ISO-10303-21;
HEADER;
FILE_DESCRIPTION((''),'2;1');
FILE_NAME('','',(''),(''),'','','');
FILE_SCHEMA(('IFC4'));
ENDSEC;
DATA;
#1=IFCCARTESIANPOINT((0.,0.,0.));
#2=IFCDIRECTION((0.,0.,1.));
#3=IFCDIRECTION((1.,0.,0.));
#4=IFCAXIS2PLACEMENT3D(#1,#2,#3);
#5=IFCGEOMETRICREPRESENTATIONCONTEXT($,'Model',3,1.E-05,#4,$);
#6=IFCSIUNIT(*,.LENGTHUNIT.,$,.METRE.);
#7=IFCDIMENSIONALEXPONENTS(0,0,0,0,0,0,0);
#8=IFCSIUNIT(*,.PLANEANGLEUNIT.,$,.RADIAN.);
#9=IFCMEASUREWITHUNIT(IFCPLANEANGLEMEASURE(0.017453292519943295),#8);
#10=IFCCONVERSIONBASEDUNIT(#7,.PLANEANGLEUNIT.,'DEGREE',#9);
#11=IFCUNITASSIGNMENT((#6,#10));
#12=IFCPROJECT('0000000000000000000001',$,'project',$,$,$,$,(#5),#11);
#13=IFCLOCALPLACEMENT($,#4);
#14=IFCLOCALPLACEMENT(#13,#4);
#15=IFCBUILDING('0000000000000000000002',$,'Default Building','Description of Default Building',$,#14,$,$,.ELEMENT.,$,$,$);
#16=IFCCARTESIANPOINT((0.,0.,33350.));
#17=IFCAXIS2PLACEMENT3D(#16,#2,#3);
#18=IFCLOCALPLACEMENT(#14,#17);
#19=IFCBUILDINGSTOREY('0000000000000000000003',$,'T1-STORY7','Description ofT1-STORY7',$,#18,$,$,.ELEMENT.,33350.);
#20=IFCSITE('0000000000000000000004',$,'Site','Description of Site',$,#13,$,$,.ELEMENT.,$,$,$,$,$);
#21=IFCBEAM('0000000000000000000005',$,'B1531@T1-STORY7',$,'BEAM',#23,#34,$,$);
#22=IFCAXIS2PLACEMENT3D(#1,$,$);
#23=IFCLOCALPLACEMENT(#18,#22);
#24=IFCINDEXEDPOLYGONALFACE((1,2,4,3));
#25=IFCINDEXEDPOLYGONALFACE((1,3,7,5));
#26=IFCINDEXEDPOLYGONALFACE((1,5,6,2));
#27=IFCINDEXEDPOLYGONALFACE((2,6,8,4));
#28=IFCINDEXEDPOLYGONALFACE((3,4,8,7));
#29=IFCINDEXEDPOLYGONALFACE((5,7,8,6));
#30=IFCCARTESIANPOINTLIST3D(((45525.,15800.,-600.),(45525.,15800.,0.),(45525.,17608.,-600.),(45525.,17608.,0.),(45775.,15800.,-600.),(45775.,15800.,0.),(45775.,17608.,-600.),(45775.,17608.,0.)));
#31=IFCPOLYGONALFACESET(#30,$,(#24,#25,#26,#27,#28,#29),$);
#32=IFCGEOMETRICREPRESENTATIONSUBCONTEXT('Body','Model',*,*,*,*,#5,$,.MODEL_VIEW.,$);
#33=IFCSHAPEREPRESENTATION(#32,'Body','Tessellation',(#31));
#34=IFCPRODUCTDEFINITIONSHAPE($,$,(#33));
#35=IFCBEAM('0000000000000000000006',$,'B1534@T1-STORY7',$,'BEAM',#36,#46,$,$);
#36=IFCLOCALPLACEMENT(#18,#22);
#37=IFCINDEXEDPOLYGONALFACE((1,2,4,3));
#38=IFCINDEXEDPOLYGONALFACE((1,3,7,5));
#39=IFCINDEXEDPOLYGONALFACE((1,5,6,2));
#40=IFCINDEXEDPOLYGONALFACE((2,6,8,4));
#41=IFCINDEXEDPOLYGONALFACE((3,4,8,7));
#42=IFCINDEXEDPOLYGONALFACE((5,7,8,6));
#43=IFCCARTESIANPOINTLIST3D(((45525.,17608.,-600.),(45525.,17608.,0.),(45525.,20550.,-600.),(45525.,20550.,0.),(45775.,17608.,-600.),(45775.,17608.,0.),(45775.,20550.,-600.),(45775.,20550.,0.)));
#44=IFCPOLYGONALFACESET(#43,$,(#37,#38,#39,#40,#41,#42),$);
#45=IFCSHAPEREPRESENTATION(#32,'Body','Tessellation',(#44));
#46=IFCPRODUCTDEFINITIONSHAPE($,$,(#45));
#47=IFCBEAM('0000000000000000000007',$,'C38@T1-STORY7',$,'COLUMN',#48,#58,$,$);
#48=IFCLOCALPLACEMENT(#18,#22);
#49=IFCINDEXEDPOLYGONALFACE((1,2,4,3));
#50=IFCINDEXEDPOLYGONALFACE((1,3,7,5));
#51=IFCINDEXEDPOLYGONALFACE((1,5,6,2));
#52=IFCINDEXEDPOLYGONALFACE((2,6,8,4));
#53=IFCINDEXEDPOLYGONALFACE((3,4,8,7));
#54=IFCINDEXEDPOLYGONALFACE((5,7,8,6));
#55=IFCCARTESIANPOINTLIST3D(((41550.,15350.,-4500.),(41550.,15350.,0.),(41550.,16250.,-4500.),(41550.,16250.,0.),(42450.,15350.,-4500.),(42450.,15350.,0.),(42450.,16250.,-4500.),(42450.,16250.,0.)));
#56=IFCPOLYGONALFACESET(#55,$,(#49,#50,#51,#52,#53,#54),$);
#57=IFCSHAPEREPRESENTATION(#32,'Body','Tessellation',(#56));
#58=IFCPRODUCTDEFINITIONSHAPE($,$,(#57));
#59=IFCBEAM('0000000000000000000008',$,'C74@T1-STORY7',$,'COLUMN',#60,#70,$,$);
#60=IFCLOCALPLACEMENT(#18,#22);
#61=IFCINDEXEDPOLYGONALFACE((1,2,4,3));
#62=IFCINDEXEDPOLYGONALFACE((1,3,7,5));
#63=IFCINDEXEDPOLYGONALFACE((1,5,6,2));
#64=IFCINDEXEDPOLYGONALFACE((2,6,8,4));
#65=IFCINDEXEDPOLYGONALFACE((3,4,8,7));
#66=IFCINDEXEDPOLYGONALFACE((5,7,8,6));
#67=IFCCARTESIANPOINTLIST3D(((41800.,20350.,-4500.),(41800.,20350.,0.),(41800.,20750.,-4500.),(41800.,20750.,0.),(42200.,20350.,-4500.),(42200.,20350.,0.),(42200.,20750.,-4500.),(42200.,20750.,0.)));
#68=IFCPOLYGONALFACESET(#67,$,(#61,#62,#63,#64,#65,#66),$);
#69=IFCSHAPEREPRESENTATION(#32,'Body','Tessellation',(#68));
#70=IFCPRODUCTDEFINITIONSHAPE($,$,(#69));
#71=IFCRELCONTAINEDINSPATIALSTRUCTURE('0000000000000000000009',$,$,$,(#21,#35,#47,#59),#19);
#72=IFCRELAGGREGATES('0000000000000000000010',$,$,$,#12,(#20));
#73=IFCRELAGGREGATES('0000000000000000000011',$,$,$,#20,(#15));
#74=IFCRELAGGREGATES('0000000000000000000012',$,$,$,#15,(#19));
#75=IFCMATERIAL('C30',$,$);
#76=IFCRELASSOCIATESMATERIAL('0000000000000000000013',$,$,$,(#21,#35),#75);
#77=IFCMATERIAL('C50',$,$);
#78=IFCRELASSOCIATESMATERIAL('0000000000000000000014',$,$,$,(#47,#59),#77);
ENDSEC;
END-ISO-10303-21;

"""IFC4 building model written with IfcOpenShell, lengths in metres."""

from ifc_helpers import new_model, entity, si_unit, converted_unit, frame, origin_with_axes, place, context, subcontext, project, spatial, rectangle, extrude, material, element, save


model = new_model("IFC4")

# Units and contexts
model_context = context("Model", 3, precision=1e-05, world=origin_with_axes())
body_context = subcontext(model_context, "Body", "Model", "MODEL_VIEW")
ifc_project = project(units=[si_unit("LENGTHUNIT", "METRE"), converted_unit("PLANEANGLEUNIT", "DEGREE", entity("IfcPlaneAngleMeasure", 0.017453292519943295), si_unit("PLANEANGLEUNIT", "RADIAN"), dimensions=[0, 0, 0, 0, 0, 0, 0])], contexts=[model_context])

# Site, building, storey
site_placement = place(None, origin_with_axes())
site = spatial("IfcSite", under=ifc_project, at=site_placement, Name="Site", Description="Description of Site", CompositionType="ELEMENT")
building_placement = place(site_placement, origin_with_axes())
building = spatial("IfcBuilding", under=site, at=building_placement, Name="Default Building", Description="Description of Default Building", CompositionType="ELEMENT")
storey_placement = place(building_placement, frame((0.0, 0.0, 33350.0), z_axis=(0.0, 0.0, 1.0), x_axis=(1.0, 0.0, 0.0)))
storey = spatial("IfcBuildingStorey", under=building, at=storey_placement, Name="T1-STORY7", Description="Description ofT1-STORY7", CompositionType="ELEMENT", Elevation=33350.0)

# Beams
ifc_material_1 = material(Name="C30")
beam_1_placement = place(storey_placement, frame((45650.0, 15800.0, -300.0), z_axis=(0.0, 1.0, 0.0), x_axis=(-1.0, 0.0, 0.0)))
element("IfcBeam", 1, at=beam_1_placement, inside=storey, material=ifc_material_1, Name="B1531@T1-STORY7", ObjectType="BEAM", context=body_context, shape_type="SweptSolid", body=[
    extrude(rectangle(XDim=250.0, YDim=600.0), origin_with_axes(), (0.0, 0.0, 1.0), 1808.0),
])
beam_2_placement = place(storey_placement, frame((45650.0, 17608.0, -300.0), z_axis=(0.0, 1.0, 0.0), x_axis=(-1.0, 0.0, 0.0)))
element("IfcBeam", 2, at=beam_2_placement, inside=storey, material=ifc_material_1, Name="B1534@T1-STORY7", ObjectType="BEAM", context=body_context, shape_type="SweptSolid", body=[
    extrude(rectangle(XDim=250.0, YDim=600.0), origin_with_axes(), (0.0, 0.0, 1.0), 2942.0),
])
ifc_material_2 = material(Name="C50")
beam_3_placement = place(storey_placement, frame((42000.0, 15800.0, -4500.0), z_axis=(0.0, 0.0, 1.0), x_axis=(-1.0, 0.0, 0.0)))
element("IfcBeam", 3, at=beam_3_placement, inside=storey, material=ifc_material_2, Name="C38@T1-STORY7", ObjectType="COLUMN", context=body_context, shape_type="SweptSolid", body=[
    extrude(rectangle(XDim=900.0, YDim=900.0), origin_with_axes(), (0.0, 0.0, 1.0), 4500.0),
])
beam_4_placement = place(storey_placement, frame((42000.0, 20550.0, -4500.0), z_axis=(0.0, 0.0, 1.0), x_axis=(-1.0, 0.0, 0.0)))
element("IfcBeam", 4, at=beam_4_placement, inside=storey, material=ifc_material_2, Name="C74@T1-STORY7", ObjectType="COLUMN", context=body_context, shape_type="SweptSolid", body=[
    extrude(rectangle(XDim=400.0, YDim=400.0), origin_with_axes(), (0.0, 0.0, 1.0), 4500.0),
])

save(model, "model.ifc")
